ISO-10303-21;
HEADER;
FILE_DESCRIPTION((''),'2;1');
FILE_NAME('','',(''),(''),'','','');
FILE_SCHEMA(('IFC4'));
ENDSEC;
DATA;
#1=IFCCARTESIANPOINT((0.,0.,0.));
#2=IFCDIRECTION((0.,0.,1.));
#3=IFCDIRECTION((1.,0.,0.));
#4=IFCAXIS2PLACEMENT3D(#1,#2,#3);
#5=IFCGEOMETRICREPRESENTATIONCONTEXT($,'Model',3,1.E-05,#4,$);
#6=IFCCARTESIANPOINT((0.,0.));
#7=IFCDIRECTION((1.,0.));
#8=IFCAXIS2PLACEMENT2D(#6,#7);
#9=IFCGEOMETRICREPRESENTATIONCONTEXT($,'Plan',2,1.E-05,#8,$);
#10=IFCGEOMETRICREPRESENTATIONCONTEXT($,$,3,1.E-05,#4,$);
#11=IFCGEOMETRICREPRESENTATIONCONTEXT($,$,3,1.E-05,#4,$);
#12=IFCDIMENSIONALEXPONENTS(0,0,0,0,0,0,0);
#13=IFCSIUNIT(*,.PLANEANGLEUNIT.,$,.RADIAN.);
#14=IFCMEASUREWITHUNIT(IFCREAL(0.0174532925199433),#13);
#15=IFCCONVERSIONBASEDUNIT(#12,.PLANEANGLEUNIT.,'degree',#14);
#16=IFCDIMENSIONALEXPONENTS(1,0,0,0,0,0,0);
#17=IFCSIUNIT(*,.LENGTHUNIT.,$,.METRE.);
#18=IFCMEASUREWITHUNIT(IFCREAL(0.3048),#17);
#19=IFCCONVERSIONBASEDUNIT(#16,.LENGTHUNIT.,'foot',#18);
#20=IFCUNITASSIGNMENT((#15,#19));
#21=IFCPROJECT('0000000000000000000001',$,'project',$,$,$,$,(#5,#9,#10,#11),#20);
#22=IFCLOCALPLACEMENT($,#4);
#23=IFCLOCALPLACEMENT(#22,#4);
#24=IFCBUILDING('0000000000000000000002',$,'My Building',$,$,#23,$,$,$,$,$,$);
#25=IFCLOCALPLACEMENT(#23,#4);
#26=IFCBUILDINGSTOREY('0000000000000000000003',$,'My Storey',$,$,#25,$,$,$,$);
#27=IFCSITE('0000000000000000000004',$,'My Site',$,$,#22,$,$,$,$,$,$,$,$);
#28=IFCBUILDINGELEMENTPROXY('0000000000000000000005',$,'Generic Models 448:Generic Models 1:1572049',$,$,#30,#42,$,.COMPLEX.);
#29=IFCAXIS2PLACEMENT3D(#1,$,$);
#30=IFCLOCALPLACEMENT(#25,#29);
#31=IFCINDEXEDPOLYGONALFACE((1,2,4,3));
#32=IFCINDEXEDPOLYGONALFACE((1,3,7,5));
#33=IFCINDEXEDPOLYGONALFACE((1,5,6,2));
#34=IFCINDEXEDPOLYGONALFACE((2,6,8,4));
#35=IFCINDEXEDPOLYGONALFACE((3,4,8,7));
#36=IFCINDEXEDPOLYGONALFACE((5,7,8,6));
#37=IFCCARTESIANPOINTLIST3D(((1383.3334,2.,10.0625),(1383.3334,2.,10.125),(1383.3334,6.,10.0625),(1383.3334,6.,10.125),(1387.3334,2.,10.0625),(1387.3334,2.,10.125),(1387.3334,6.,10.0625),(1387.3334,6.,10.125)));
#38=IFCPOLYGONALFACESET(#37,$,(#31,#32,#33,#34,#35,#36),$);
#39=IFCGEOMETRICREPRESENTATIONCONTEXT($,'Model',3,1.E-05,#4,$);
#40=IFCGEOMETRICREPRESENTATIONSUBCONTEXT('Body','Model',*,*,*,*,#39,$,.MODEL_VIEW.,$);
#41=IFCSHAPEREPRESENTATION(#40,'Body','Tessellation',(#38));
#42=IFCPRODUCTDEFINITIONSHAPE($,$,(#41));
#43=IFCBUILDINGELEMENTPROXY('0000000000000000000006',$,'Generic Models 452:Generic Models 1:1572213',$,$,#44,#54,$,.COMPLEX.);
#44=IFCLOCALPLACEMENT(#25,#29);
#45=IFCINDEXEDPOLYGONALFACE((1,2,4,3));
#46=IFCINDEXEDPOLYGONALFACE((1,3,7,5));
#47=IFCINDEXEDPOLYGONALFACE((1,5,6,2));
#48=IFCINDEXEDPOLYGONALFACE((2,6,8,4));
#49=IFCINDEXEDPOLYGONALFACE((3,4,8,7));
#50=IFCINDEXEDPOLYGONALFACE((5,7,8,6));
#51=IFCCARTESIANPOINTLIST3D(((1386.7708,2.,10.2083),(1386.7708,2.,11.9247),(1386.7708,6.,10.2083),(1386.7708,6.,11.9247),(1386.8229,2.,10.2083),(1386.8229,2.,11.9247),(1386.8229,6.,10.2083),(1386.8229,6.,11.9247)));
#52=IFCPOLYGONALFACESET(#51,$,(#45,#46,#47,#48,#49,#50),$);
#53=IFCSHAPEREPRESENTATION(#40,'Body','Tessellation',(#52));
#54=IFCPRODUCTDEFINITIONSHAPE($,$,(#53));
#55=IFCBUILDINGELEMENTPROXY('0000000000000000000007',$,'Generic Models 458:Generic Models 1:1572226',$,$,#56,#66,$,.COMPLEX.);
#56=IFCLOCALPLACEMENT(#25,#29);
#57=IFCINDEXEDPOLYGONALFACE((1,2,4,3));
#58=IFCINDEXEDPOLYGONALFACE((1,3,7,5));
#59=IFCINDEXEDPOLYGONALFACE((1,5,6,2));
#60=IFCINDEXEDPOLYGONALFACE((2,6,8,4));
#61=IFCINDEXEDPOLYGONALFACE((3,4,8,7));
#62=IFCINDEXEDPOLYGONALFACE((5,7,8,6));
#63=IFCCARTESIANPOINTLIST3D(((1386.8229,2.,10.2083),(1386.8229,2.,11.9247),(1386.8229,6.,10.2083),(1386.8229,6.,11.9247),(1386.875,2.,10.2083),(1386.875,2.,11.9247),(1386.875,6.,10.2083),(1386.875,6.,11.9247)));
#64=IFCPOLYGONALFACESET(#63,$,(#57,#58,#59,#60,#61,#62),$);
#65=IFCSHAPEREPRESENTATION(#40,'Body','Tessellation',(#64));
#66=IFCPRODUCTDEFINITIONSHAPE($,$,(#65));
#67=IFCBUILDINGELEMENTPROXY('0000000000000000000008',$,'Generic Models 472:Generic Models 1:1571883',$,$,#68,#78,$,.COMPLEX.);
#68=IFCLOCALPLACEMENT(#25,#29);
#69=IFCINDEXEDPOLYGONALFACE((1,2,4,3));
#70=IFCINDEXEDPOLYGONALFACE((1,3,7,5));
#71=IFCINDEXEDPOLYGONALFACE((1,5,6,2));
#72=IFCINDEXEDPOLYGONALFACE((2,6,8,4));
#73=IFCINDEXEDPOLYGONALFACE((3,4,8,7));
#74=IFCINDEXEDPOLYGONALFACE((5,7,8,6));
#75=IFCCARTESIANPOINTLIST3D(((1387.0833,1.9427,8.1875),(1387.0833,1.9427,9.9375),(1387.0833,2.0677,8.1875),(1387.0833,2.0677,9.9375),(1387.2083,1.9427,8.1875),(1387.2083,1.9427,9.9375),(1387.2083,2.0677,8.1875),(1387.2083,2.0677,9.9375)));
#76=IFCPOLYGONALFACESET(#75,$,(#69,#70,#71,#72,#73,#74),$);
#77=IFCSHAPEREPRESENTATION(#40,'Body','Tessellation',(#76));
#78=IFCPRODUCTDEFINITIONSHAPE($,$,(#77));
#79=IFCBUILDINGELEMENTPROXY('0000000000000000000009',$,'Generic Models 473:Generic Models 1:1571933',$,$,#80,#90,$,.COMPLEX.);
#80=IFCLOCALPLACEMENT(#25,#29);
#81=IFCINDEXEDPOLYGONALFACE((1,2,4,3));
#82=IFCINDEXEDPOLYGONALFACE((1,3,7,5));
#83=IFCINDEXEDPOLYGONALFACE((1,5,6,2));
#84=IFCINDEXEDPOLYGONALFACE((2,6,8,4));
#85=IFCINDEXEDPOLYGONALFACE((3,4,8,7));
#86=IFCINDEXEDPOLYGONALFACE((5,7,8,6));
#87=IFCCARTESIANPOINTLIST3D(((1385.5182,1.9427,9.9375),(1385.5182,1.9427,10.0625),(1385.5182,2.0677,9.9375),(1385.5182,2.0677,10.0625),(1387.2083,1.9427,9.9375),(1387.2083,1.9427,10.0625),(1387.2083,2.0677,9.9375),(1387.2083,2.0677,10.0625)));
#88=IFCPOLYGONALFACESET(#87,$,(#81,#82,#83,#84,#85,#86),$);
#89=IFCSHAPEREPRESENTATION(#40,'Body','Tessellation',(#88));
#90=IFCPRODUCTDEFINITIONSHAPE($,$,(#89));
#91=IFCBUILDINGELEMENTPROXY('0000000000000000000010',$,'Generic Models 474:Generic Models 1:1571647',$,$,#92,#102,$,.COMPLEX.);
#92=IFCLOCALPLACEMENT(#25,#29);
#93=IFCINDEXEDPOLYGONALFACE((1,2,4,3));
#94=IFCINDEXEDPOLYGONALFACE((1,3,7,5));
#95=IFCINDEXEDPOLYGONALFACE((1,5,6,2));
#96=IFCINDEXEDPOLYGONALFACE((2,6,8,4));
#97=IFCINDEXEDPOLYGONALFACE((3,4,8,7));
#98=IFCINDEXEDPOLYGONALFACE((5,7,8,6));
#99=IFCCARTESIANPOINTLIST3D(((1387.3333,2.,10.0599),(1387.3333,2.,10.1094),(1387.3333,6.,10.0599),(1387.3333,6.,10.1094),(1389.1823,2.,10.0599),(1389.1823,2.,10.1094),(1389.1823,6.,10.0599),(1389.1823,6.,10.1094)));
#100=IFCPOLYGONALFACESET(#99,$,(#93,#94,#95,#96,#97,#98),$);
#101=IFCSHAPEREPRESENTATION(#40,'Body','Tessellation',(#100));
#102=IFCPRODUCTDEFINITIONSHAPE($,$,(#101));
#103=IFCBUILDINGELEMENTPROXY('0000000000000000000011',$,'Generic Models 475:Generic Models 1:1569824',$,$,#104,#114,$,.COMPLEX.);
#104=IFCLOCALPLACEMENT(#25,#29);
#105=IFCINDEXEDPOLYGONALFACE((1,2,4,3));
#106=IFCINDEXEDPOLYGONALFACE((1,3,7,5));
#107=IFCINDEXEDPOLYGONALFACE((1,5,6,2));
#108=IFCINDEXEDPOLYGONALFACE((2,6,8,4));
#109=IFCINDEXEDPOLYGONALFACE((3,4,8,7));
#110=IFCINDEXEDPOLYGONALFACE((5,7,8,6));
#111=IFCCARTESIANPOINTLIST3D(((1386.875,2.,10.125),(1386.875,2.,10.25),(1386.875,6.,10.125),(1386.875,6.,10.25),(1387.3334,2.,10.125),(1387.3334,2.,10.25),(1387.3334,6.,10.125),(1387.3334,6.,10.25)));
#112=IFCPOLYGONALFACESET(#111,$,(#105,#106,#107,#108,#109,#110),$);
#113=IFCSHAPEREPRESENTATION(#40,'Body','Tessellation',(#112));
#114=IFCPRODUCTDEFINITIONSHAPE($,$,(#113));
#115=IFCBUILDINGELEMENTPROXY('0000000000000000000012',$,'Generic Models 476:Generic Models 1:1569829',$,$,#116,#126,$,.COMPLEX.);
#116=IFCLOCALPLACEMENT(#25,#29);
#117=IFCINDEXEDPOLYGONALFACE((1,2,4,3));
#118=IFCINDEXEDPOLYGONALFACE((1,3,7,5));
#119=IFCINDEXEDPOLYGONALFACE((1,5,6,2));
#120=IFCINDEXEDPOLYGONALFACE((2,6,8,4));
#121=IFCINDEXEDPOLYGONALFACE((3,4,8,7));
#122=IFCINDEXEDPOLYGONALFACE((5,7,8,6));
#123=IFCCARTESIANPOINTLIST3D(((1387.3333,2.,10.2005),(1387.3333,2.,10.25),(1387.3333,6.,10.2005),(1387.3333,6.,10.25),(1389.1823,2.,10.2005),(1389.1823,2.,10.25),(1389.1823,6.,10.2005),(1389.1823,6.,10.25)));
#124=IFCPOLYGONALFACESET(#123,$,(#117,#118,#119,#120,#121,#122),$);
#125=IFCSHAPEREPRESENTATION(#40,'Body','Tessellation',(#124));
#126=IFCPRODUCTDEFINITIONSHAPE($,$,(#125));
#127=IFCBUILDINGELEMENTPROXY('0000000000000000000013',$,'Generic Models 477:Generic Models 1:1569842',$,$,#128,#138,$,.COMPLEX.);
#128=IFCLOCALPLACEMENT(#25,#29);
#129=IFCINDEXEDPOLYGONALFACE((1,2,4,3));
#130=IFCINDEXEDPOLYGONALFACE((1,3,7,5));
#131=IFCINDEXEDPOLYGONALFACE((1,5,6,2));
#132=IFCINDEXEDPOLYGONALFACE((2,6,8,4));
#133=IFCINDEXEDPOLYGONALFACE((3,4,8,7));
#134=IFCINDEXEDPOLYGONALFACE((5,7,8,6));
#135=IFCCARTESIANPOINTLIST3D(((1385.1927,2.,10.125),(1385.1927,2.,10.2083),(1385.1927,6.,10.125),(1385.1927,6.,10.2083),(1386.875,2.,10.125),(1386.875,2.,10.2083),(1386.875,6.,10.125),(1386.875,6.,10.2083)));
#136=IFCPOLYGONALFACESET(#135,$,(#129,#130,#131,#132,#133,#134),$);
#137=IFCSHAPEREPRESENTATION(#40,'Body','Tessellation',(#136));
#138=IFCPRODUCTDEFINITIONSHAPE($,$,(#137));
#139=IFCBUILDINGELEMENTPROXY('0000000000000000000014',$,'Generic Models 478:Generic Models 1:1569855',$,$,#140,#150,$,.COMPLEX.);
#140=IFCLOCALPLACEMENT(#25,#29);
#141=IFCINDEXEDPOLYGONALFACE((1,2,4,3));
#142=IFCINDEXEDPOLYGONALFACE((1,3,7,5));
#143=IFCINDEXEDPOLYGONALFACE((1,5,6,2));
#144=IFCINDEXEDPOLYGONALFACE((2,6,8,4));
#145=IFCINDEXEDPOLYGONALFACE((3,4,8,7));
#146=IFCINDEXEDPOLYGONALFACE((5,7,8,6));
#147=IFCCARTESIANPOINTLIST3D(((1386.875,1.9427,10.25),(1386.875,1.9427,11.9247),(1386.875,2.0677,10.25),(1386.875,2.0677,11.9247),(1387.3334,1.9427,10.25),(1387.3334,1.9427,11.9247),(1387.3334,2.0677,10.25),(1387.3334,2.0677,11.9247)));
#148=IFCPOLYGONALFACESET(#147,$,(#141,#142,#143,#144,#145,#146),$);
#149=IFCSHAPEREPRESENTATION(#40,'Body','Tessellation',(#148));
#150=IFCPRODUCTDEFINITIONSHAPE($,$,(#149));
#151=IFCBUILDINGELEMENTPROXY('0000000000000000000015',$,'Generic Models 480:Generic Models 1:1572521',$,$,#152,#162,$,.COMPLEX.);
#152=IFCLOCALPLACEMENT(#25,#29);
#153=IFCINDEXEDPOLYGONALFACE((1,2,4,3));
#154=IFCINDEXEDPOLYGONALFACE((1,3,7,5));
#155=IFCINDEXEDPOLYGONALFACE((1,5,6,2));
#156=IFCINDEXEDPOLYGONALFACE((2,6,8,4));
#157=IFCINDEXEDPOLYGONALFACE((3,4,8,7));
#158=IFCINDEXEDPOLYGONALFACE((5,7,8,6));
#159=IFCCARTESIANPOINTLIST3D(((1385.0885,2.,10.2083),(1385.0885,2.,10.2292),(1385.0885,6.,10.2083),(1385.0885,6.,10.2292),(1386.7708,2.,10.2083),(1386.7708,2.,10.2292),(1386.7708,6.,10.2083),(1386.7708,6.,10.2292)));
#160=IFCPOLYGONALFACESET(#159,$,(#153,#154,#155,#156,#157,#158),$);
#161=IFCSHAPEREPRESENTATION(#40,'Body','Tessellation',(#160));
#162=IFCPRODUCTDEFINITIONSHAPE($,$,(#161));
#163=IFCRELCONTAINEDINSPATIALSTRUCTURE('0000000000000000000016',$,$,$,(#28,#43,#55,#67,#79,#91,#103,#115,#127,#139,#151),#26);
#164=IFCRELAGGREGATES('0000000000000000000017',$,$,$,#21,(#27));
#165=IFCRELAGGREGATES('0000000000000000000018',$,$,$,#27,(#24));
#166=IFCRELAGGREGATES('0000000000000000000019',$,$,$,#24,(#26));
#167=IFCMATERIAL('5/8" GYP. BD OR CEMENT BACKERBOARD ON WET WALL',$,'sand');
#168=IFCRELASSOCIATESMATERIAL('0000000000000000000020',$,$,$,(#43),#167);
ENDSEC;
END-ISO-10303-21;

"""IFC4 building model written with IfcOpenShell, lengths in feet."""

from ifc_helpers import new_model, entity, si_unit, converted_unit, frame, origin_with_axes, origin_2d_with_axis, place, context, subcontext, project, spatial, polyline, outline, extrude, material, element, save


model = new_model("IFC4")

# Units and contexts
model_context_1 = context("Model", 3, precision=1e-05, world=origin_with_axes())
plan_context = context("Plan", 2, precision=1e-05, world=origin_2d_with_axis())
model_context_2 = context("Model", 3, precision=1e-05, world=origin_with_axes())
context_of_model_1 = context(None, 3, precision=1e-05, world=origin_with_axes())
context_of_model_2 = context(None, 3, precision=1e-05, world=origin_with_axes())
body_context = subcontext(model_context_2, "Body", "Model", "MODEL_VIEW")
ifc_project = project(units=[converted_unit("PLANEANGLEUNIT", "degree", entity("IfcReal", 0.0174532925199433), si_unit("PLANEANGLEUNIT", "RADIAN"), dimensions=[0, 0, 0, 0, 0, 0, 0]), converted_unit("LENGTHUNIT", "foot", entity("IfcReal", 0.3048), si_unit("LENGTHUNIT", "METRE"), dimensions=[1, 0, 0, 0, 0, 0, 0])], contexts=[model_context_1, plan_context, context_of_model_1, context_of_model_2])

# Site, building, storey
site_placement = place(None, origin_with_axes())
site = spatial("IfcSite", under=ifc_project, at=site_placement, Name="My Site")
building_placement = place(site_placement, origin_with_axes())
building = spatial("IfcBuilding", under=site, at=building_placement, Name="My Building")
storey_placement = place(building_placement, origin_with_axes())
storey = spatial("IfcBuildingStorey", under=building, at=storey_placement, Name="My Storey")

# Building element proxies
proxy_1_placement = place(storey_placement, frame((1383.3334, 6.0, 10.0625), z_axis=(0.0, -1.0, 0.0), x_axis=(0.0, 0.0, 1.0)))
element("IfcBuildingElementProxy", 1, at=proxy_1_placement, inside=storey, Name="Generic Models 448:Generic Models 1:1572049", PredefinedType="COMPLEX", context=body_context, shape_type="SweptSolid", body=[
    extrude(outline(polyline([(-0.0313, -2.0), (0.0313, -2.0), (0.0312, 2.0), (-0.0313, 2.0), (-0.0313, -2.0)])), frame((0.0313, -2.0, 0.0), z_axis=(0.0, 0.0, -1.0), x_axis=(1.0, 0.0, 0.0)), (0.0, 0.0, -1.0), 4.0),
])
ifc_material_1 = material(Name="5/8\" GYP. BD OR CEMENT BACKERBOARD ON WET WALL", Category="sand")
proxy_2_placement = place(storey_placement, frame((1386.7708, 6.0, 10.2083), z_axis=(0.0, -1.0, 0.0), x_axis=(0.0, 0.0, 1.0)))
element("IfcBuildingElementProxy", 2, at=proxy_2_placement, inside=storey, material=ifc_material_1, Name="Generic Models 452:Generic Models 1:1572213", PredefinedType="COMPLEX", context=body_context, shape_type="SweptSolid", body=[
    extrude(outline(polyline([(-0.026, -0.8582), (0.026, -0.8582), (0.026, 0.8582), (-0.026, 0.8582), (-0.026, -0.8582)])), frame((0.8582, -0.026, 0.0), z_axis=(0.0, 0.0, -1.0), x_axis=(0.0, 1.0, 0.0)), (0.0, 0.0, -1.0), 4.0),
])
proxy_3_placement = place(storey_placement, frame((1386.8229, 6.0, 10.2083), z_axis=(0.0, -1.0, 0.0), x_axis=(0.0, 0.0, 1.0)))
element("IfcBuildingElementProxy", 3, at=proxy_3_placement, inside=storey, Name="Generic Models 458:Generic Models 1:1572226", PredefinedType="COMPLEX", context=body_context, shape_type="SweptSolid", body=[
    extrude(outline(polyline([(-0.8582, -0.026), (0.8582, -0.026), (0.8582, 0.026), (-0.8582, 0.026), (-0.8582, -0.026)])), frame((0.8582, -0.026, 0.0), z_axis=(0.0, 0.0, -1.0), x_axis=(1.0, 0.0, 0.0)), (0.0, 0.0, -1.0), 4.0),
])
proxy_4_placement = place(storey_placement, frame((1387.0833, 1.9427, 8.1875), z_axis=(0.0, 0.0, 1.0), x_axis=(0.0, 1.0, 0.0)))
element("IfcBuildingElementProxy", 4, at=proxy_4_placement, inside=storey, Name="Generic Models 472:Generic Models 1:1571883", PredefinedType="COMPLEX", context=body_context, shape_type="SweptSolid", body=[
    extrude(outline(polyline([(-0.0625, -0.0625), (0.0625, -0.0625), (0.0625, 0.0625), (-0.0625, 0.0625), (-0.0625, -0.0625)])), frame((0.0625, -0.0625, 0.0), z_axis=(0.0, 0.0, -1.0), x_axis=(-1.0, 0.0, 0.0)), (0.0, 0.0, -1.0), 1.75),
])
proxy_5_placement = place(storey_placement, frame((1385.5182, 1.9427, 9.9375), z_axis=(1.0, 0.0, 0.0), x_axis=(0.0, 0.0, -1.0)))
element("IfcBuildingElementProxy", 5, at=proxy_5_placement, inside=storey, Name="Generic Models 473:Generic Models 1:1571933", PredefinedType="COMPLEX", context=body_context, shape_type="SweptSolid", body=[
    extrude(outline(polyline([(-0.0625, -0.0625), (0.0625, -0.0625), (0.0625, 0.0625), (-0.0625, 0.0625), (-0.0625, -0.0625)])), frame((-0.0625, 0.0625, 0.0), z_axis=(0.0, 0.0, -1.0), x_axis=(1.0, 0.0, 0.0)), (0.0, 0.0, -1.0), 1.6902),
])
proxy_6_placement = place(storey_placement, frame((1387.3333, 6.0, 10.0599), z_axis=(0.0, -1.0, 0.0), x_axis=(0.0, 0.0, 1.0)))
element("IfcBuildingElementProxy", 6, at=proxy_6_placement, inside=storey, Name="Generic Models 474:Generic Models 1:1571647", PredefinedType="COMPLEX", context=body_context, shape_type="SweptSolid", body=[
    extrude(outline(polyline([(-0.0247, -0.9245), (0.0247, -0.9245), (0.0247, 0.9245), (-0.0247, 0.9245), (-0.0247, -0.9245)])), frame((0.0247, -0.9245, 0.0), z_axis=(0.0, 0.0, -1.0), x_axis=(-1.0, 0.0, 0.0)), (0.0, 0.0, -1.0), 4.0),
])
proxy_7_placement = place(storey_placement, frame((1386.875, 6.0, 10.125), z_axis=(0.0, -1.0, 0.0), x_axis=(0.0, 0.0, 1.0)))
element("IfcBuildingElementProxy", 7, at=proxy_7_placement, inside=storey, Name="Generic Models 475:Generic Models 1:1569824", PredefinedType="COMPLEX", context=body_context, shape_type="SweptSolid", body=[
    extrude(outline(polyline([(-0.2292, -0.0625), (0.2292, -0.0625), (0.2292, 0.0625), (-0.2292, 0.0625), (-0.2292, -0.0625)])), frame((0.0625, -0.2292, 0.0), z_axis=(0.0, 0.0, -1.0), x_axis=(0.0, 1.0, 0.0)), (0.0, 0.0, -1.0), 4.0),
])
proxy_8_placement = place(storey_placement, frame((1387.3333, 6.0, 10.2005), z_axis=(0.0, -1.0, 0.0), x_axis=(0.0, 0.0, 1.0)))
element("IfcBuildingElementProxy", 8, at=proxy_8_placement, inside=storey, Name="Generic Models 476:Generic Models 1:1569829", PredefinedType="COMPLEX", context=body_context, shape_type="SweptSolid", body=[
    extrude(outline(polyline([(-0.0247, -0.9245), (0.0247, -0.9245), (0.0247, 0.9245), (-0.0247, 0.9245), (-0.0247, -0.9245)])), frame((0.0247, -0.9245, 0.0), z_axis=(0.0, 0.0, -1.0), x_axis=(-1.0, 0.0, 0.0)), (0.0, 0.0, -1.0), 4.0),
])
proxy_9_placement = place(storey_placement, frame((1385.1927, 6.0, 10.125), z_axis=(0.0, -1.0, 0.0), x_axis=(0.0, 0.0, 1.0)))
element("IfcBuildingElementProxy", 9, at=proxy_9_placement, inside=storey, Name="Generic Models 477:Generic Models 1:1569842", PredefinedType="COMPLEX", context=body_context, shape_type="SweptSolid", body=[
    extrude(outline(polyline([(-0.8411, -0.0417), (0.8411, -0.0417), (0.8411, 0.0417), (-0.8411, 0.0417), (-0.8411, -0.0417)])), frame((0.0417, -0.8411, 0.0), z_axis=(0.0, 0.0, -1.0), x_axis=(0.0, 1.0, 0.0)), (0.0, 0.0, -1.0), 4.0),
])
proxy_10_placement = place(storey_placement, frame((1386.875, 5.9427, 10.25), z_axis=(0.0, -1.0, 0.0), x_axis=(1.0, 0.0, 0.0)))
element("IfcBuildingElementProxy", 10, at=proxy_10_placement, inside=storey, Name="Generic Models 478:Generic Models 1:1569855", PredefinedType="COMPLEX", context=body_context, shape_type="SweptSolid", body=[
    extrude(outline(polyline([(-0.8373, -0.2292), (0.8373, -0.2292), (0.8373, 0.2292), (-0.8373, 0.2292), (-0.8373, -0.2292)])), frame((0.2292, 0.8373, 3.875), z_axis=(0.0, 0.0, -1.0), x_axis=(0.0, 1.0, 0.0)), (0.0, 0.0, -1.0), 0.125),
])
proxy_11_placement = place(storey_placement, frame((1385.0885, 6.0, 10.2083), z_axis=(0.0, -1.0, 0.0), x_axis=(0.0, 0.0, 1.0)))
element("IfcBuildingElementProxy", 11, at=proxy_11_placement, inside=storey, Name="Generic Models 480:Generic Models 1:1572521", PredefinedType="COMPLEX", context=body_context, shape_type="SweptSolid", body=[
    extrude(outline(polyline([(0.8412, 0.0), (0.841, 0.0208), (-0.8412, 0.0), (-0.841, -0.0208), (0.8412, 0.0)])), frame((0.0104, -0.8411, 0.0), z_axis=(0.0, 0.0, -1.0), x_axis=(-0.012383, 0.999923, 0.0)), (0.0, 0.0, -1.0), 4.0),
])

save(model, "model.ifc")
